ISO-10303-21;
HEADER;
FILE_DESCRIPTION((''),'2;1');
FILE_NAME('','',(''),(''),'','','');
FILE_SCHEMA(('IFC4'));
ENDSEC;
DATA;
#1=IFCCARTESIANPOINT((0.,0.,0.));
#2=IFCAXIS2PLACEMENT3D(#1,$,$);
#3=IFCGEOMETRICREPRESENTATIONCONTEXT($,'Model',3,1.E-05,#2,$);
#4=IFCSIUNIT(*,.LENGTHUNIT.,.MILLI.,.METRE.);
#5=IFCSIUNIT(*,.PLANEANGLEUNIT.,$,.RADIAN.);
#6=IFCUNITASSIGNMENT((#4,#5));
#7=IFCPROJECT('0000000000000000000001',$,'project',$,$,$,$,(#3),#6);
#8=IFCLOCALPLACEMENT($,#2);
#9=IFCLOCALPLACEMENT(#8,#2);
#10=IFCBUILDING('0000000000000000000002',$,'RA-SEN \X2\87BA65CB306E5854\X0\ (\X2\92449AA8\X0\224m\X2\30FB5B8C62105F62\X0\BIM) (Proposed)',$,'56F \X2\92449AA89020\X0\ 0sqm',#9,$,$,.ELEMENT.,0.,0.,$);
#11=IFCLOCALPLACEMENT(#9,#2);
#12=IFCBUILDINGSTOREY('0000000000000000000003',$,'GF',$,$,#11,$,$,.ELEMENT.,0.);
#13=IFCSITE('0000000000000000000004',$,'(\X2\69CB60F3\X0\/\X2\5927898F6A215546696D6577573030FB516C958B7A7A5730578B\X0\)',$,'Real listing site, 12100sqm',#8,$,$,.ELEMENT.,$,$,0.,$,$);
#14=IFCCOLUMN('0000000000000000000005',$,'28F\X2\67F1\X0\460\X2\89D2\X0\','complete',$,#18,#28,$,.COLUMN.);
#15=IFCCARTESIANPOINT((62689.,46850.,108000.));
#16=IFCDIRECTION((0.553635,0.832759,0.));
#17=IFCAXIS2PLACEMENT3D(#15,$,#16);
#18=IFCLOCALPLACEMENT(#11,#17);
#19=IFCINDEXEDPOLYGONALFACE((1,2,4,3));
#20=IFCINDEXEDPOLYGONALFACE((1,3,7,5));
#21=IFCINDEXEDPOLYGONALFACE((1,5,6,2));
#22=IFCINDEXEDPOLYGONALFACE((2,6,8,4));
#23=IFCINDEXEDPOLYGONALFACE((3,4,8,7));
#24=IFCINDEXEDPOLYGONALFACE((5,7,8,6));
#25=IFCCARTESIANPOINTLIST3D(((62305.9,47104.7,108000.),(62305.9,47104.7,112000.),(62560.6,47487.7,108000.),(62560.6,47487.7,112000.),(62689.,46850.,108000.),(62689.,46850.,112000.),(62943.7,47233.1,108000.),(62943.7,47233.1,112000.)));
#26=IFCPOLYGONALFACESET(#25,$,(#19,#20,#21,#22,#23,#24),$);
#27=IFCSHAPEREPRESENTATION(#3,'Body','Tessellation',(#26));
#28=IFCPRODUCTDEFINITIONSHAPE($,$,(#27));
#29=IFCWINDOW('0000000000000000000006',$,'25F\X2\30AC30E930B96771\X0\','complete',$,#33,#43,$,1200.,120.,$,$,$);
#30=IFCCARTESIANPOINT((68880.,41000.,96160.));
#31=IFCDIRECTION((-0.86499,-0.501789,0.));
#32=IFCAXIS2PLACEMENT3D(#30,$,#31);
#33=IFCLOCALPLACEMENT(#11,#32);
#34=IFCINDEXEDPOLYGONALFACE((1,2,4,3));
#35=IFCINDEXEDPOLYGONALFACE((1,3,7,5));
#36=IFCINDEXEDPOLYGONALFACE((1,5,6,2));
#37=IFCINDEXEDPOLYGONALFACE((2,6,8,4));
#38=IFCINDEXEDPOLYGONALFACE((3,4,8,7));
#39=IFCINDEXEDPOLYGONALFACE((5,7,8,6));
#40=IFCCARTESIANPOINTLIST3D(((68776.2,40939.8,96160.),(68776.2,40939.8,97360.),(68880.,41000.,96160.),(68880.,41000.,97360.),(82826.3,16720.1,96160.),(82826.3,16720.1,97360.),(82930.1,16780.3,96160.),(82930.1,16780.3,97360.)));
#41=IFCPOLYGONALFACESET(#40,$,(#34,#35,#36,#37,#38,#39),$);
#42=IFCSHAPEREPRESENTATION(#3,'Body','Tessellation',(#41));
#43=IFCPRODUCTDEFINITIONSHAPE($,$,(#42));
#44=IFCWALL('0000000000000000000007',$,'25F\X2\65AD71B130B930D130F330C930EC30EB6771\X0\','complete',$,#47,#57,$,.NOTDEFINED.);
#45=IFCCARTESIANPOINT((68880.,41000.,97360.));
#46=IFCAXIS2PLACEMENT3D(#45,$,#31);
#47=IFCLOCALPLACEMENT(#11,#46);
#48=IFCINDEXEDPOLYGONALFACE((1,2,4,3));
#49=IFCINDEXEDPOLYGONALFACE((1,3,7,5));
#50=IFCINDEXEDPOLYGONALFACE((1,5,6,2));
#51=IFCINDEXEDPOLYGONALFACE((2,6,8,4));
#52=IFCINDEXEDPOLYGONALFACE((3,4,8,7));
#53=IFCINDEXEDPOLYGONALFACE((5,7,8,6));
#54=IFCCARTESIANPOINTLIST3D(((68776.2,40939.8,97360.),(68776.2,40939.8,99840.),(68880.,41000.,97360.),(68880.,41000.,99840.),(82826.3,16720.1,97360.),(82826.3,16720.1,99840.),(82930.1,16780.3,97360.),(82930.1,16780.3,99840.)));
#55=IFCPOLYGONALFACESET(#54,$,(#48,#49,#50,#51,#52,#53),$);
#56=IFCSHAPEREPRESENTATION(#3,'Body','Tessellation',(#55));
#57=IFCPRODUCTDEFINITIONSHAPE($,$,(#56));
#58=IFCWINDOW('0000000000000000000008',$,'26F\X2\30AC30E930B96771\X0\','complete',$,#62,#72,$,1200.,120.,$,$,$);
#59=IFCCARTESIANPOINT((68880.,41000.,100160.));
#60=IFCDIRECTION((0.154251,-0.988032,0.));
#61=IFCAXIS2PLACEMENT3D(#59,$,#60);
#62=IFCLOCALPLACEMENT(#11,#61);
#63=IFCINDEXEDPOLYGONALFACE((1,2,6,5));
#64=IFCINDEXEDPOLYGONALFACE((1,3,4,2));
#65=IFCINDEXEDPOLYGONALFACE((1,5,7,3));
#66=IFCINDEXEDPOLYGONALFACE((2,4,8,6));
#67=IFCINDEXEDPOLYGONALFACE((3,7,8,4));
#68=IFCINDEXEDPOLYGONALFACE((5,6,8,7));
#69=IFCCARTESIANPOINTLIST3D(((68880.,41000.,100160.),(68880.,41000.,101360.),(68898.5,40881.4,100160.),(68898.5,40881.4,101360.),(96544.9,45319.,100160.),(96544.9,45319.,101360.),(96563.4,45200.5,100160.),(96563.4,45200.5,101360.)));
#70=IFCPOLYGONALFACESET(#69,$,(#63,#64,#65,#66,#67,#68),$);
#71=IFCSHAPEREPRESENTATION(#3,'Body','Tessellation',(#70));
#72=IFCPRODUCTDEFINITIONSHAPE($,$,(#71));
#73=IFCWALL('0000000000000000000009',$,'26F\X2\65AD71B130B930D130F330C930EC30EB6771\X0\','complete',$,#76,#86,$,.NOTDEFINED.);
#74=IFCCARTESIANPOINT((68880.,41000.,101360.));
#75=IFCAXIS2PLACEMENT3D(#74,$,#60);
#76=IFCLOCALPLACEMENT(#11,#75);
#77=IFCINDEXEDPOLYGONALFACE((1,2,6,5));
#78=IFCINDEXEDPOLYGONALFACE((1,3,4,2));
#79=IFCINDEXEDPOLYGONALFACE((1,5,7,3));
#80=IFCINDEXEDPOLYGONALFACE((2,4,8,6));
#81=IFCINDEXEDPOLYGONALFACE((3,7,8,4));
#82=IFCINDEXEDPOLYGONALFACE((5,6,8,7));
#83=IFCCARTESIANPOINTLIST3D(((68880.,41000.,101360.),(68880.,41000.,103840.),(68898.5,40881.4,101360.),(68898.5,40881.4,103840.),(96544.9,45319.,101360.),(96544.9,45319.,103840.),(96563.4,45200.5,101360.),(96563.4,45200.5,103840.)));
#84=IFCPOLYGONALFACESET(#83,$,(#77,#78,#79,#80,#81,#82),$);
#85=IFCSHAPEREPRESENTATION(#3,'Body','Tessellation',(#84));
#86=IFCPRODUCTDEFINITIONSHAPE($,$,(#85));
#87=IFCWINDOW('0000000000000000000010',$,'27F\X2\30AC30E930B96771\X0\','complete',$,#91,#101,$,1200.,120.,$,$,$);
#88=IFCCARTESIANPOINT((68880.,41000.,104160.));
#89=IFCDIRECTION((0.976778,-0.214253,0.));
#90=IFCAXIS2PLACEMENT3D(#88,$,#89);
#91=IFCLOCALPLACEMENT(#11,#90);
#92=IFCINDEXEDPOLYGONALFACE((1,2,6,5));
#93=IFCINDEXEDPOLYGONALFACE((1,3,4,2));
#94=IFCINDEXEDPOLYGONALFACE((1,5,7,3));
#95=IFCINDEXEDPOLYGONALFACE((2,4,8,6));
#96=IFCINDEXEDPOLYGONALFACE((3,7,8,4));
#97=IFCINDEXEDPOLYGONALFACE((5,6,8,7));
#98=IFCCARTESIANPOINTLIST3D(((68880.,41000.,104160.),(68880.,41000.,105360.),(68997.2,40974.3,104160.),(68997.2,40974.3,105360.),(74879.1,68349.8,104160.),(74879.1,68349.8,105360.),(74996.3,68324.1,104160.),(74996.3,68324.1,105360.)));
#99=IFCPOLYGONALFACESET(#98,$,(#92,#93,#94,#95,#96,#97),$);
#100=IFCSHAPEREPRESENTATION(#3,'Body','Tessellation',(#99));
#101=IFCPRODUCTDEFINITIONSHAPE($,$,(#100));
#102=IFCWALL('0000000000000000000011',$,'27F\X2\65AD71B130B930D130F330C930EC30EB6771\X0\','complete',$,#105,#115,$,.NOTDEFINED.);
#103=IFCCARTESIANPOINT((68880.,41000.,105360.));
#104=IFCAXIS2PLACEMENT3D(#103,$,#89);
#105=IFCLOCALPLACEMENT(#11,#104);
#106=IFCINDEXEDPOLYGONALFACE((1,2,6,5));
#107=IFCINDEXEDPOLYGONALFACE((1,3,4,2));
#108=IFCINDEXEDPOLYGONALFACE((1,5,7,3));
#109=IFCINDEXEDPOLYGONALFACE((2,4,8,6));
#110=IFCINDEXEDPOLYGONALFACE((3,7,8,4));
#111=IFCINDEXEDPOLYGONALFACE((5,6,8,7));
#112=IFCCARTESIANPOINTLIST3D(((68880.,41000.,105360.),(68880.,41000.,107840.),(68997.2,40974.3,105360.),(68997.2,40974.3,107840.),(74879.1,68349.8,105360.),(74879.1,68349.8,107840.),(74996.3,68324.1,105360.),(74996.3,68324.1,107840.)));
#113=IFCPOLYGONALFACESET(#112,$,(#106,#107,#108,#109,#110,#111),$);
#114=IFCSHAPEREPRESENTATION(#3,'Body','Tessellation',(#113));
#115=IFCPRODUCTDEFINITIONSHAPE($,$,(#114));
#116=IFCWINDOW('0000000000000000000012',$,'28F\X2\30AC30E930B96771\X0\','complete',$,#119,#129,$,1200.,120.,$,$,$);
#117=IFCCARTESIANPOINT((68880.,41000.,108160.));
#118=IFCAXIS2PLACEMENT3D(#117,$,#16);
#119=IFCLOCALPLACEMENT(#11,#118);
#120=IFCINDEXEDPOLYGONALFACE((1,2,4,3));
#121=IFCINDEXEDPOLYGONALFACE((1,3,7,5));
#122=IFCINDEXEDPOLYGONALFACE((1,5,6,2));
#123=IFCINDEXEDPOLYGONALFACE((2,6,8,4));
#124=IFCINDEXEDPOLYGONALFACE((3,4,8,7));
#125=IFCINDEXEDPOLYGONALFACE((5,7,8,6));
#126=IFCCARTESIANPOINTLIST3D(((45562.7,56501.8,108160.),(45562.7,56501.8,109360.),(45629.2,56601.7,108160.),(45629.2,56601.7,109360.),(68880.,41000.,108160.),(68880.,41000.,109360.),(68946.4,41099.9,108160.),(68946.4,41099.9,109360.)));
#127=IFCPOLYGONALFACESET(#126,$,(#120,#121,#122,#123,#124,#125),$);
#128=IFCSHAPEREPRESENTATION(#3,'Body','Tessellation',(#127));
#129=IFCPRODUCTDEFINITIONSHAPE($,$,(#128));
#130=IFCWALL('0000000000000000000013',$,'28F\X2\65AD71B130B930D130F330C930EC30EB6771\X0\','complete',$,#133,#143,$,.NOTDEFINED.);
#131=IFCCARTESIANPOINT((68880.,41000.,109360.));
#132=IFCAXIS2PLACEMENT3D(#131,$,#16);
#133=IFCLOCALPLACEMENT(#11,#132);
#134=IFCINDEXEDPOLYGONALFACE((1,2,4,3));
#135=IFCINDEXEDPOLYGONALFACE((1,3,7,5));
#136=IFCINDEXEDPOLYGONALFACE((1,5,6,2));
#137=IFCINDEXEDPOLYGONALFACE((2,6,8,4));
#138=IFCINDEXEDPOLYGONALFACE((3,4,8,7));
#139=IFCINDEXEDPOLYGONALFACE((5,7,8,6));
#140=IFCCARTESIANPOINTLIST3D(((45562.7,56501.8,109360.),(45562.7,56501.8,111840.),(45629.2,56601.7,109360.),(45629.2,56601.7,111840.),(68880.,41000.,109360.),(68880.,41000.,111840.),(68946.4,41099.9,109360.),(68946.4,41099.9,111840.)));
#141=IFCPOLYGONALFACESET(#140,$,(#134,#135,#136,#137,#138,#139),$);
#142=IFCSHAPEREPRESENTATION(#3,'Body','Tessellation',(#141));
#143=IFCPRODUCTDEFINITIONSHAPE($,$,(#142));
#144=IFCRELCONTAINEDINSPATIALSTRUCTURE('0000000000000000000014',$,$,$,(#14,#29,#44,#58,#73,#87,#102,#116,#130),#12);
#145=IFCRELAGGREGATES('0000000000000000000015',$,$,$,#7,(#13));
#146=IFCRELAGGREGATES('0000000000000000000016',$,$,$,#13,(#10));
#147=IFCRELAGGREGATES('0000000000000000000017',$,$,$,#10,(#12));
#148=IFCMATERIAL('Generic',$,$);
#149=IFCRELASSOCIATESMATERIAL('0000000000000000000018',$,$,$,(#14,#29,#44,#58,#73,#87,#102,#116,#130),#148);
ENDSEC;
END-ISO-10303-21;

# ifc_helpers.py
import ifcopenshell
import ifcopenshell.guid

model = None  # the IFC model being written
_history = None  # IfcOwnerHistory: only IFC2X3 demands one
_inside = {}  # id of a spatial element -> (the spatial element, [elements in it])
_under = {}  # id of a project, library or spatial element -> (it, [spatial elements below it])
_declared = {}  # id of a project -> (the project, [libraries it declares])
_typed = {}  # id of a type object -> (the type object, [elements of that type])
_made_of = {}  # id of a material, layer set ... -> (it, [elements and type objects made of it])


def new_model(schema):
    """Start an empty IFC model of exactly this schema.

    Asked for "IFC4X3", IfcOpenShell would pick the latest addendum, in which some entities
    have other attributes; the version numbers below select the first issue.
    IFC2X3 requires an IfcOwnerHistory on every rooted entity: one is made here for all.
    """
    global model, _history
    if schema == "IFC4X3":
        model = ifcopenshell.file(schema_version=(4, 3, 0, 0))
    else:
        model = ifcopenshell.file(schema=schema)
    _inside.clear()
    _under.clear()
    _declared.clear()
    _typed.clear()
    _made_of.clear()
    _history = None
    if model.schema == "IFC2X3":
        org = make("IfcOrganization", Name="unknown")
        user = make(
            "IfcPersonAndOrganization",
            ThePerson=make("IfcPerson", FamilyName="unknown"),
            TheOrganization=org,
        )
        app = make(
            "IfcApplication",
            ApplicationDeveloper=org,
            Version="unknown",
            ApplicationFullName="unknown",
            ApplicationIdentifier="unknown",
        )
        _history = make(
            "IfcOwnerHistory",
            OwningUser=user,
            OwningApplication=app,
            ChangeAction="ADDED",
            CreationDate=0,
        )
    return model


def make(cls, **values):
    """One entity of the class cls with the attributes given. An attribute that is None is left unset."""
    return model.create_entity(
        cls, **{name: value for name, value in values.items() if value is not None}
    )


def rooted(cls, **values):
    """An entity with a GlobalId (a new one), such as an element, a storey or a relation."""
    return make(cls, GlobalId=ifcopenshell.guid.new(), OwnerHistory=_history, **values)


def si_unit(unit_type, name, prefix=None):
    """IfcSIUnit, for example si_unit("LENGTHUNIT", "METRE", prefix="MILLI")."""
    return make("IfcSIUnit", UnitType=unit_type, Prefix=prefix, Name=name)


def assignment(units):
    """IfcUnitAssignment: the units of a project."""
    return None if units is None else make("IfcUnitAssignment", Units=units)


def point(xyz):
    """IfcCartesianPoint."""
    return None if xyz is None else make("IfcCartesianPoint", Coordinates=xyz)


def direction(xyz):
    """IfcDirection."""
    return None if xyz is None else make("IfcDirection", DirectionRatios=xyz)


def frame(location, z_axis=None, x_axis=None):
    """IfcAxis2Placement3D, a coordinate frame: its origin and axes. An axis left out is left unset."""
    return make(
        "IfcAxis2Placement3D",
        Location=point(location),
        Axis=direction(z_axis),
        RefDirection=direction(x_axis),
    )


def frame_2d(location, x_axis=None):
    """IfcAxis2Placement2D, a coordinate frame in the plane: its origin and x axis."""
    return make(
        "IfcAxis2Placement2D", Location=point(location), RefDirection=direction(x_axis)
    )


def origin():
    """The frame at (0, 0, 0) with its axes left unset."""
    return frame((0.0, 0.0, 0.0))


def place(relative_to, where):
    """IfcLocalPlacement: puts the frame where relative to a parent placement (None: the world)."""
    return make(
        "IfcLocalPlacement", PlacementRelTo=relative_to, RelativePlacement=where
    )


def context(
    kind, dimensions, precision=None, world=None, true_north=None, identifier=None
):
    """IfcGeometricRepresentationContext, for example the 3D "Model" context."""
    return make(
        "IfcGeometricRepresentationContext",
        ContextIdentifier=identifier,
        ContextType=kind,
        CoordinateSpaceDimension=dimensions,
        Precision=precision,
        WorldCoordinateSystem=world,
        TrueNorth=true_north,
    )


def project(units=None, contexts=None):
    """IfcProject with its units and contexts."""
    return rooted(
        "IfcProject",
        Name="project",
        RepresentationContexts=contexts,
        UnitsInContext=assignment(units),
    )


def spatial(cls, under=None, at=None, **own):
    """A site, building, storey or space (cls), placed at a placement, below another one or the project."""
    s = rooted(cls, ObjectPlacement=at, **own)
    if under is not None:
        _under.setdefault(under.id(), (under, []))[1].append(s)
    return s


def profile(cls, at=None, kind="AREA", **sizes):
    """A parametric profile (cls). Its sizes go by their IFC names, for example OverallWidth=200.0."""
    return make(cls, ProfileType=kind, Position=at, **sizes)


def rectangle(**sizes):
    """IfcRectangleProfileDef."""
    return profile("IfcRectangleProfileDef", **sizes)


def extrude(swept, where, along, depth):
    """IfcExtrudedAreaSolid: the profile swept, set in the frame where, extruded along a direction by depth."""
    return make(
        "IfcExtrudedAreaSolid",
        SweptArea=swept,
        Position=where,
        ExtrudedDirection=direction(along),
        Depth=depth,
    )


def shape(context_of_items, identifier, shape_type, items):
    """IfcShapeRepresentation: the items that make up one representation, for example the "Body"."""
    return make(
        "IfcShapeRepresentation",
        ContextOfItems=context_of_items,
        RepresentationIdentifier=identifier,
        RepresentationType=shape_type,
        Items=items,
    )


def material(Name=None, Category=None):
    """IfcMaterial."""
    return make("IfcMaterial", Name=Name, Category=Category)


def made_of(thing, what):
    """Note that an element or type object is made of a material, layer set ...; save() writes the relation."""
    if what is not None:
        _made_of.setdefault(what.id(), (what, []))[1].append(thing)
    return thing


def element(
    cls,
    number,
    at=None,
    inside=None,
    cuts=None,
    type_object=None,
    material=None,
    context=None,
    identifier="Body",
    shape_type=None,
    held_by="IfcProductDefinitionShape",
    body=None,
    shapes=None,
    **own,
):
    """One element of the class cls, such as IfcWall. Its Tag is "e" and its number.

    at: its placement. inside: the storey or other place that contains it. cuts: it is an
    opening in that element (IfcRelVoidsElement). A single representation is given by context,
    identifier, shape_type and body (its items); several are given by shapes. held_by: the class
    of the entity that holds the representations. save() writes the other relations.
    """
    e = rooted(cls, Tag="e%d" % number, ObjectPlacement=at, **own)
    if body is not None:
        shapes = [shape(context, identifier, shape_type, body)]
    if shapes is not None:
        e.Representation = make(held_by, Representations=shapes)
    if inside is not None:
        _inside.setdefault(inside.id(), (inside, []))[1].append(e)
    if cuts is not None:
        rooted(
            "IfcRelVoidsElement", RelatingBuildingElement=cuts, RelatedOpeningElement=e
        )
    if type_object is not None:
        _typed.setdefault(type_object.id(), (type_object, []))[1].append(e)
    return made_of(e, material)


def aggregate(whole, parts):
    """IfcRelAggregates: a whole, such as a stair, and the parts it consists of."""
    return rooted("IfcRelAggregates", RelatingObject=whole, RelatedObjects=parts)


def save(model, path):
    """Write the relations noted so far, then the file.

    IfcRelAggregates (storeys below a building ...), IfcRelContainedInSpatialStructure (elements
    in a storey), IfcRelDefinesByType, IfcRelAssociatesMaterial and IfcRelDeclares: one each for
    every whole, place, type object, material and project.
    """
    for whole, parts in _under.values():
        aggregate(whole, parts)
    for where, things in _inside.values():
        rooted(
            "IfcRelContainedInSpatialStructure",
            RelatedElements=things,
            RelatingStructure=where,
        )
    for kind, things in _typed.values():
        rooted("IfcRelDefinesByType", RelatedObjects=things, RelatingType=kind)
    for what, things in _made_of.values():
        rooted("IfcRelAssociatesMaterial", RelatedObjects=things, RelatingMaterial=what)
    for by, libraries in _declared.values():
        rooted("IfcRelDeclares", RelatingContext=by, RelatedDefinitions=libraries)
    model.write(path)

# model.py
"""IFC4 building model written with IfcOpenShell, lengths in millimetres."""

from ifc_helpers import new_model, si_unit, frame, frame_2d, origin, place, context, project, spatial, rectangle, extrude, material, element, save


model = new_model("IFC4")

# Units and contexts
model_context = context("Model", 3, precision=1e-05, world=origin())
ifc_project = project(units=[si_unit("LENGTHUNIT", "METRE", prefix="MILLI"), si_unit("PLANEANGLEUNIT", "RADIAN")], contexts=[model_context])

# Site, building, storey
site_placement = place(None, origin())
site = spatial("IfcSite", under=ifc_project, at=site_placement, Name="(構想/大規模商業敷地・公開空地型)", ObjectType="Real listing site, 12100sqm", CompositionType="ELEMENT", RefElevation=0.0)
building_placement = place(site_placement, origin())
building = spatial("IfcBuilding", under=site, at=building_placement, Name="RA-SEN 螺旋の塔 (鉄骨224m・完成形BIM) (Proposed)", ObjectType="56F 鉄骨造 0sqm", CompositionType="ELEMENT", ElevationOfRefHeight=0.0, ElevationOfTerrain=0.0)
storey_placement = place(building_placement, origin())
storey = spatial("IfcBuildingStorey", under=building, at=storey_placement, Name="GF", CompositionType="ELEMENT", Elevation=0.0)

# Column
ifc_material = material(Name="Generic")
column_1_placement = place(storey_placement, frame((62689.0, 46850.0, 108000.0), x_axis=(0.553635, 0.832759, 0.0)))
element("IfcColumn", 1, at=column_1_placement, inside=storey, material=ifc_material, Name="28F柱460角", Description="complete", PredefinedType="COLUMN", context=model_context, shape_type="SweptSolid", body=[
    extrude(rectangle(XDim=460.0, YDim=460.0, at=frame_2d((230.0, 230.0))), frame((62689.0, 46850.0, 108000.0), x_axis=(0.553635, 0.832759, 0.0)), (0.0, 0.0, 1.0), 4000.0),
])

# Window
window_1_placement = place(storey_placement, frame((68880.0, 41000.0, 96160.0), x_axis=(-0.86499, -0.501789, 0.0)))
element("IfcWindow", 2, at=window_1_placement, inside=storey, material=ifc_material, Name="25Fガラス東", Description="complete", OverallHeight=1200.0, OverallWidth=120.0, context=model_context, shape_type="SweptSolid", body=[
    extrude(rectangle(XDim=120.0, YDim=28000.0, at=frame_2d((60.0, 14000.0))), frame((68880.0, 41000.0, 96160.0), x_axis=(-0.86499, -0.501789, 0.0)), (0.0, 0.0, 1.0), 1200.0),
])

# Wall
wall_1_placement = place(storey_placement, frame((68880.0, 41000.0, 97360.0), x_axis=(-0.86499, -0.501789, 0.0)))
element("IfcWall", 3, at=wall_1_placement, inside=storey, material=ifc_material, Name="25F断熱スパンドレル東", Description="complete", PredefinedType="NOTDEFINED", context=model_context, shape_type="SweptSolid", body=[
    extrude(rectangle(XDim=120.0, YDim=28000.0, at=frame_2d((60.0, 14000.0))), frame((68880.0, 41000.0, 97360.0), x_axis=(-0.86499, -0.501789, 0.0)), (0.0, 0.0, 1.0), 2480.0),
])

# Window
window_2_placement = place(storey_placement, frame((68880.0, 41000.0, 100160.0), x_axis=(0.154251, -0.988032, 0.0)))
element("IfcWindow", 4, at=window_2_placement, inside=storey, material=ifc_material, Name="26Fガラス東", Description="complete", OverallHeight=1200.0, OverallWidth=120.0, context=model_context, shape_type="SweptSolid", body=[
    extrude(rectangle(XDim=120.0, YDim=28000.0, at=frame_2d((60.0, 14000.0))), frame((68880.0, 41000.0, 100160.0), x_axis=(0.154251, -0.988032, 0.0)), (0.0, 0.0, 1.0), 1200.0),
])

# Wall
wall_2_placement = place(storey_placement, frame((68880.0, 41000.0, 101360.0), x_axis=(0.154251, -0.988032, 0.0)))
element("IfcWall", 5, at=wall_2_placement, inside=storey, material=ifc_material, Name="26F断熱スパンドレル東", Description="complete", PredefinedType="NOTDEFINED", context=model_context, shape_type="SweptSolid", body=[
    extrude(rectangle(XDim=120.0, YDim=28000.0, at=frame_2d((60.0, 14000.0))), frame((68880.0, 41000.0, 101360.0), x_axis=(0.154251, -0.988032, 0.0)), (0.0, 0.0, 1.0), 2480.0),
])

# Window
window_3_placement = place(storey_placement, frame((68880.0, 41000.0, 104160.0), x_axis=(0.976778, -0.214253, 0.0)))
element("IfcWindow", 6, at=window_3_placement, inside=storey, material=ifc_material, Name="27Fガラス東", Description="complete", OverallHeight=1200.0, OverallWidth=120.0, context=model_context, shape_type="SweptSolid", body=[
    extrude(rectangle(XDim=120.0, YDim=28000.0, at=frame_2d((60.0, 14000.0))), frame((68880.0, 41000.0, 104160.0), x_axis=(0.976778, -0.214253, 0.0)), (0.0, 0.0, 1.0), 1200.0),
])

# Wall
wall_3_placement = place(storey_placement, frame((68880.0, 41000.0, 105360.0), x_axis=(0.976778, -0.214253, 0.0)))
element("IfcWall", 7, at=wall_3_placement, inside=storey, material=ifc_material, Name="27F断熱スパンドレル東", Description="complete", PredefinedType="NOTDEFINED", context=model_context, shape_type="SweptSolid", body=[
    extrude(rectangle(XDim=120.0, YDim=28000.0, at=frame_2d((60.0, 14000.0))), frame((68880.0, 41000.0, 105360.0), x_axis=(0.976778, -0.214253, 0.0)), (0.0, 0.0, 1.0), 2480.0),
])

# Window
window_4_placement = place(storey_placement, frame((68880.0, 41000.0, 108160.0), x_axis=(0.553635, 0.832759, 0.0)))
element("IfcWindow", 8, at=window_4_placement, inside=storey, material=ifc_material, Name="28Fガラス東", Description="complete", OverallHeight=1200.0, OverallWidth=120.0, context=model_context, shape_type="SweptSolid", body=[
    extrude(rectangle(XDim=120.0, YDim=28000.0, at=frame_2d((60.0, 14000.0))), frame((68880.0, 41000.0, 108160.0), x_axis=(0.553635, 0.832759, 0.0)), (0.0, 0.0, 1.0), 1200.0),
])

# Wall
wall_4_placement = place(storey_placement, frame((68880.0, 41000.0, 109360.0), x_axis=(0.553635, 0.832759, 0.0)))
element("IfcWall", 9, at=wall_4_placement, inside=storey, material=ifc_material, Name="28F断熱スパンドレル東", Description="complete", PredefinedType="NOTDEFINED", context=model_context, shape_type="SweptSolid", body=[
    extrude(rectangle(XDim=120.0, YDim=28000.0, at=frame_2d((60.0, 14000.0))), frame((68880.0, 41000.0, 109360.0), x_axis=(0.553635, 0.832759, 0.0)), (0.0, 0.0, 1.0), 2480.0),
])

save(model, "model.ifc")
